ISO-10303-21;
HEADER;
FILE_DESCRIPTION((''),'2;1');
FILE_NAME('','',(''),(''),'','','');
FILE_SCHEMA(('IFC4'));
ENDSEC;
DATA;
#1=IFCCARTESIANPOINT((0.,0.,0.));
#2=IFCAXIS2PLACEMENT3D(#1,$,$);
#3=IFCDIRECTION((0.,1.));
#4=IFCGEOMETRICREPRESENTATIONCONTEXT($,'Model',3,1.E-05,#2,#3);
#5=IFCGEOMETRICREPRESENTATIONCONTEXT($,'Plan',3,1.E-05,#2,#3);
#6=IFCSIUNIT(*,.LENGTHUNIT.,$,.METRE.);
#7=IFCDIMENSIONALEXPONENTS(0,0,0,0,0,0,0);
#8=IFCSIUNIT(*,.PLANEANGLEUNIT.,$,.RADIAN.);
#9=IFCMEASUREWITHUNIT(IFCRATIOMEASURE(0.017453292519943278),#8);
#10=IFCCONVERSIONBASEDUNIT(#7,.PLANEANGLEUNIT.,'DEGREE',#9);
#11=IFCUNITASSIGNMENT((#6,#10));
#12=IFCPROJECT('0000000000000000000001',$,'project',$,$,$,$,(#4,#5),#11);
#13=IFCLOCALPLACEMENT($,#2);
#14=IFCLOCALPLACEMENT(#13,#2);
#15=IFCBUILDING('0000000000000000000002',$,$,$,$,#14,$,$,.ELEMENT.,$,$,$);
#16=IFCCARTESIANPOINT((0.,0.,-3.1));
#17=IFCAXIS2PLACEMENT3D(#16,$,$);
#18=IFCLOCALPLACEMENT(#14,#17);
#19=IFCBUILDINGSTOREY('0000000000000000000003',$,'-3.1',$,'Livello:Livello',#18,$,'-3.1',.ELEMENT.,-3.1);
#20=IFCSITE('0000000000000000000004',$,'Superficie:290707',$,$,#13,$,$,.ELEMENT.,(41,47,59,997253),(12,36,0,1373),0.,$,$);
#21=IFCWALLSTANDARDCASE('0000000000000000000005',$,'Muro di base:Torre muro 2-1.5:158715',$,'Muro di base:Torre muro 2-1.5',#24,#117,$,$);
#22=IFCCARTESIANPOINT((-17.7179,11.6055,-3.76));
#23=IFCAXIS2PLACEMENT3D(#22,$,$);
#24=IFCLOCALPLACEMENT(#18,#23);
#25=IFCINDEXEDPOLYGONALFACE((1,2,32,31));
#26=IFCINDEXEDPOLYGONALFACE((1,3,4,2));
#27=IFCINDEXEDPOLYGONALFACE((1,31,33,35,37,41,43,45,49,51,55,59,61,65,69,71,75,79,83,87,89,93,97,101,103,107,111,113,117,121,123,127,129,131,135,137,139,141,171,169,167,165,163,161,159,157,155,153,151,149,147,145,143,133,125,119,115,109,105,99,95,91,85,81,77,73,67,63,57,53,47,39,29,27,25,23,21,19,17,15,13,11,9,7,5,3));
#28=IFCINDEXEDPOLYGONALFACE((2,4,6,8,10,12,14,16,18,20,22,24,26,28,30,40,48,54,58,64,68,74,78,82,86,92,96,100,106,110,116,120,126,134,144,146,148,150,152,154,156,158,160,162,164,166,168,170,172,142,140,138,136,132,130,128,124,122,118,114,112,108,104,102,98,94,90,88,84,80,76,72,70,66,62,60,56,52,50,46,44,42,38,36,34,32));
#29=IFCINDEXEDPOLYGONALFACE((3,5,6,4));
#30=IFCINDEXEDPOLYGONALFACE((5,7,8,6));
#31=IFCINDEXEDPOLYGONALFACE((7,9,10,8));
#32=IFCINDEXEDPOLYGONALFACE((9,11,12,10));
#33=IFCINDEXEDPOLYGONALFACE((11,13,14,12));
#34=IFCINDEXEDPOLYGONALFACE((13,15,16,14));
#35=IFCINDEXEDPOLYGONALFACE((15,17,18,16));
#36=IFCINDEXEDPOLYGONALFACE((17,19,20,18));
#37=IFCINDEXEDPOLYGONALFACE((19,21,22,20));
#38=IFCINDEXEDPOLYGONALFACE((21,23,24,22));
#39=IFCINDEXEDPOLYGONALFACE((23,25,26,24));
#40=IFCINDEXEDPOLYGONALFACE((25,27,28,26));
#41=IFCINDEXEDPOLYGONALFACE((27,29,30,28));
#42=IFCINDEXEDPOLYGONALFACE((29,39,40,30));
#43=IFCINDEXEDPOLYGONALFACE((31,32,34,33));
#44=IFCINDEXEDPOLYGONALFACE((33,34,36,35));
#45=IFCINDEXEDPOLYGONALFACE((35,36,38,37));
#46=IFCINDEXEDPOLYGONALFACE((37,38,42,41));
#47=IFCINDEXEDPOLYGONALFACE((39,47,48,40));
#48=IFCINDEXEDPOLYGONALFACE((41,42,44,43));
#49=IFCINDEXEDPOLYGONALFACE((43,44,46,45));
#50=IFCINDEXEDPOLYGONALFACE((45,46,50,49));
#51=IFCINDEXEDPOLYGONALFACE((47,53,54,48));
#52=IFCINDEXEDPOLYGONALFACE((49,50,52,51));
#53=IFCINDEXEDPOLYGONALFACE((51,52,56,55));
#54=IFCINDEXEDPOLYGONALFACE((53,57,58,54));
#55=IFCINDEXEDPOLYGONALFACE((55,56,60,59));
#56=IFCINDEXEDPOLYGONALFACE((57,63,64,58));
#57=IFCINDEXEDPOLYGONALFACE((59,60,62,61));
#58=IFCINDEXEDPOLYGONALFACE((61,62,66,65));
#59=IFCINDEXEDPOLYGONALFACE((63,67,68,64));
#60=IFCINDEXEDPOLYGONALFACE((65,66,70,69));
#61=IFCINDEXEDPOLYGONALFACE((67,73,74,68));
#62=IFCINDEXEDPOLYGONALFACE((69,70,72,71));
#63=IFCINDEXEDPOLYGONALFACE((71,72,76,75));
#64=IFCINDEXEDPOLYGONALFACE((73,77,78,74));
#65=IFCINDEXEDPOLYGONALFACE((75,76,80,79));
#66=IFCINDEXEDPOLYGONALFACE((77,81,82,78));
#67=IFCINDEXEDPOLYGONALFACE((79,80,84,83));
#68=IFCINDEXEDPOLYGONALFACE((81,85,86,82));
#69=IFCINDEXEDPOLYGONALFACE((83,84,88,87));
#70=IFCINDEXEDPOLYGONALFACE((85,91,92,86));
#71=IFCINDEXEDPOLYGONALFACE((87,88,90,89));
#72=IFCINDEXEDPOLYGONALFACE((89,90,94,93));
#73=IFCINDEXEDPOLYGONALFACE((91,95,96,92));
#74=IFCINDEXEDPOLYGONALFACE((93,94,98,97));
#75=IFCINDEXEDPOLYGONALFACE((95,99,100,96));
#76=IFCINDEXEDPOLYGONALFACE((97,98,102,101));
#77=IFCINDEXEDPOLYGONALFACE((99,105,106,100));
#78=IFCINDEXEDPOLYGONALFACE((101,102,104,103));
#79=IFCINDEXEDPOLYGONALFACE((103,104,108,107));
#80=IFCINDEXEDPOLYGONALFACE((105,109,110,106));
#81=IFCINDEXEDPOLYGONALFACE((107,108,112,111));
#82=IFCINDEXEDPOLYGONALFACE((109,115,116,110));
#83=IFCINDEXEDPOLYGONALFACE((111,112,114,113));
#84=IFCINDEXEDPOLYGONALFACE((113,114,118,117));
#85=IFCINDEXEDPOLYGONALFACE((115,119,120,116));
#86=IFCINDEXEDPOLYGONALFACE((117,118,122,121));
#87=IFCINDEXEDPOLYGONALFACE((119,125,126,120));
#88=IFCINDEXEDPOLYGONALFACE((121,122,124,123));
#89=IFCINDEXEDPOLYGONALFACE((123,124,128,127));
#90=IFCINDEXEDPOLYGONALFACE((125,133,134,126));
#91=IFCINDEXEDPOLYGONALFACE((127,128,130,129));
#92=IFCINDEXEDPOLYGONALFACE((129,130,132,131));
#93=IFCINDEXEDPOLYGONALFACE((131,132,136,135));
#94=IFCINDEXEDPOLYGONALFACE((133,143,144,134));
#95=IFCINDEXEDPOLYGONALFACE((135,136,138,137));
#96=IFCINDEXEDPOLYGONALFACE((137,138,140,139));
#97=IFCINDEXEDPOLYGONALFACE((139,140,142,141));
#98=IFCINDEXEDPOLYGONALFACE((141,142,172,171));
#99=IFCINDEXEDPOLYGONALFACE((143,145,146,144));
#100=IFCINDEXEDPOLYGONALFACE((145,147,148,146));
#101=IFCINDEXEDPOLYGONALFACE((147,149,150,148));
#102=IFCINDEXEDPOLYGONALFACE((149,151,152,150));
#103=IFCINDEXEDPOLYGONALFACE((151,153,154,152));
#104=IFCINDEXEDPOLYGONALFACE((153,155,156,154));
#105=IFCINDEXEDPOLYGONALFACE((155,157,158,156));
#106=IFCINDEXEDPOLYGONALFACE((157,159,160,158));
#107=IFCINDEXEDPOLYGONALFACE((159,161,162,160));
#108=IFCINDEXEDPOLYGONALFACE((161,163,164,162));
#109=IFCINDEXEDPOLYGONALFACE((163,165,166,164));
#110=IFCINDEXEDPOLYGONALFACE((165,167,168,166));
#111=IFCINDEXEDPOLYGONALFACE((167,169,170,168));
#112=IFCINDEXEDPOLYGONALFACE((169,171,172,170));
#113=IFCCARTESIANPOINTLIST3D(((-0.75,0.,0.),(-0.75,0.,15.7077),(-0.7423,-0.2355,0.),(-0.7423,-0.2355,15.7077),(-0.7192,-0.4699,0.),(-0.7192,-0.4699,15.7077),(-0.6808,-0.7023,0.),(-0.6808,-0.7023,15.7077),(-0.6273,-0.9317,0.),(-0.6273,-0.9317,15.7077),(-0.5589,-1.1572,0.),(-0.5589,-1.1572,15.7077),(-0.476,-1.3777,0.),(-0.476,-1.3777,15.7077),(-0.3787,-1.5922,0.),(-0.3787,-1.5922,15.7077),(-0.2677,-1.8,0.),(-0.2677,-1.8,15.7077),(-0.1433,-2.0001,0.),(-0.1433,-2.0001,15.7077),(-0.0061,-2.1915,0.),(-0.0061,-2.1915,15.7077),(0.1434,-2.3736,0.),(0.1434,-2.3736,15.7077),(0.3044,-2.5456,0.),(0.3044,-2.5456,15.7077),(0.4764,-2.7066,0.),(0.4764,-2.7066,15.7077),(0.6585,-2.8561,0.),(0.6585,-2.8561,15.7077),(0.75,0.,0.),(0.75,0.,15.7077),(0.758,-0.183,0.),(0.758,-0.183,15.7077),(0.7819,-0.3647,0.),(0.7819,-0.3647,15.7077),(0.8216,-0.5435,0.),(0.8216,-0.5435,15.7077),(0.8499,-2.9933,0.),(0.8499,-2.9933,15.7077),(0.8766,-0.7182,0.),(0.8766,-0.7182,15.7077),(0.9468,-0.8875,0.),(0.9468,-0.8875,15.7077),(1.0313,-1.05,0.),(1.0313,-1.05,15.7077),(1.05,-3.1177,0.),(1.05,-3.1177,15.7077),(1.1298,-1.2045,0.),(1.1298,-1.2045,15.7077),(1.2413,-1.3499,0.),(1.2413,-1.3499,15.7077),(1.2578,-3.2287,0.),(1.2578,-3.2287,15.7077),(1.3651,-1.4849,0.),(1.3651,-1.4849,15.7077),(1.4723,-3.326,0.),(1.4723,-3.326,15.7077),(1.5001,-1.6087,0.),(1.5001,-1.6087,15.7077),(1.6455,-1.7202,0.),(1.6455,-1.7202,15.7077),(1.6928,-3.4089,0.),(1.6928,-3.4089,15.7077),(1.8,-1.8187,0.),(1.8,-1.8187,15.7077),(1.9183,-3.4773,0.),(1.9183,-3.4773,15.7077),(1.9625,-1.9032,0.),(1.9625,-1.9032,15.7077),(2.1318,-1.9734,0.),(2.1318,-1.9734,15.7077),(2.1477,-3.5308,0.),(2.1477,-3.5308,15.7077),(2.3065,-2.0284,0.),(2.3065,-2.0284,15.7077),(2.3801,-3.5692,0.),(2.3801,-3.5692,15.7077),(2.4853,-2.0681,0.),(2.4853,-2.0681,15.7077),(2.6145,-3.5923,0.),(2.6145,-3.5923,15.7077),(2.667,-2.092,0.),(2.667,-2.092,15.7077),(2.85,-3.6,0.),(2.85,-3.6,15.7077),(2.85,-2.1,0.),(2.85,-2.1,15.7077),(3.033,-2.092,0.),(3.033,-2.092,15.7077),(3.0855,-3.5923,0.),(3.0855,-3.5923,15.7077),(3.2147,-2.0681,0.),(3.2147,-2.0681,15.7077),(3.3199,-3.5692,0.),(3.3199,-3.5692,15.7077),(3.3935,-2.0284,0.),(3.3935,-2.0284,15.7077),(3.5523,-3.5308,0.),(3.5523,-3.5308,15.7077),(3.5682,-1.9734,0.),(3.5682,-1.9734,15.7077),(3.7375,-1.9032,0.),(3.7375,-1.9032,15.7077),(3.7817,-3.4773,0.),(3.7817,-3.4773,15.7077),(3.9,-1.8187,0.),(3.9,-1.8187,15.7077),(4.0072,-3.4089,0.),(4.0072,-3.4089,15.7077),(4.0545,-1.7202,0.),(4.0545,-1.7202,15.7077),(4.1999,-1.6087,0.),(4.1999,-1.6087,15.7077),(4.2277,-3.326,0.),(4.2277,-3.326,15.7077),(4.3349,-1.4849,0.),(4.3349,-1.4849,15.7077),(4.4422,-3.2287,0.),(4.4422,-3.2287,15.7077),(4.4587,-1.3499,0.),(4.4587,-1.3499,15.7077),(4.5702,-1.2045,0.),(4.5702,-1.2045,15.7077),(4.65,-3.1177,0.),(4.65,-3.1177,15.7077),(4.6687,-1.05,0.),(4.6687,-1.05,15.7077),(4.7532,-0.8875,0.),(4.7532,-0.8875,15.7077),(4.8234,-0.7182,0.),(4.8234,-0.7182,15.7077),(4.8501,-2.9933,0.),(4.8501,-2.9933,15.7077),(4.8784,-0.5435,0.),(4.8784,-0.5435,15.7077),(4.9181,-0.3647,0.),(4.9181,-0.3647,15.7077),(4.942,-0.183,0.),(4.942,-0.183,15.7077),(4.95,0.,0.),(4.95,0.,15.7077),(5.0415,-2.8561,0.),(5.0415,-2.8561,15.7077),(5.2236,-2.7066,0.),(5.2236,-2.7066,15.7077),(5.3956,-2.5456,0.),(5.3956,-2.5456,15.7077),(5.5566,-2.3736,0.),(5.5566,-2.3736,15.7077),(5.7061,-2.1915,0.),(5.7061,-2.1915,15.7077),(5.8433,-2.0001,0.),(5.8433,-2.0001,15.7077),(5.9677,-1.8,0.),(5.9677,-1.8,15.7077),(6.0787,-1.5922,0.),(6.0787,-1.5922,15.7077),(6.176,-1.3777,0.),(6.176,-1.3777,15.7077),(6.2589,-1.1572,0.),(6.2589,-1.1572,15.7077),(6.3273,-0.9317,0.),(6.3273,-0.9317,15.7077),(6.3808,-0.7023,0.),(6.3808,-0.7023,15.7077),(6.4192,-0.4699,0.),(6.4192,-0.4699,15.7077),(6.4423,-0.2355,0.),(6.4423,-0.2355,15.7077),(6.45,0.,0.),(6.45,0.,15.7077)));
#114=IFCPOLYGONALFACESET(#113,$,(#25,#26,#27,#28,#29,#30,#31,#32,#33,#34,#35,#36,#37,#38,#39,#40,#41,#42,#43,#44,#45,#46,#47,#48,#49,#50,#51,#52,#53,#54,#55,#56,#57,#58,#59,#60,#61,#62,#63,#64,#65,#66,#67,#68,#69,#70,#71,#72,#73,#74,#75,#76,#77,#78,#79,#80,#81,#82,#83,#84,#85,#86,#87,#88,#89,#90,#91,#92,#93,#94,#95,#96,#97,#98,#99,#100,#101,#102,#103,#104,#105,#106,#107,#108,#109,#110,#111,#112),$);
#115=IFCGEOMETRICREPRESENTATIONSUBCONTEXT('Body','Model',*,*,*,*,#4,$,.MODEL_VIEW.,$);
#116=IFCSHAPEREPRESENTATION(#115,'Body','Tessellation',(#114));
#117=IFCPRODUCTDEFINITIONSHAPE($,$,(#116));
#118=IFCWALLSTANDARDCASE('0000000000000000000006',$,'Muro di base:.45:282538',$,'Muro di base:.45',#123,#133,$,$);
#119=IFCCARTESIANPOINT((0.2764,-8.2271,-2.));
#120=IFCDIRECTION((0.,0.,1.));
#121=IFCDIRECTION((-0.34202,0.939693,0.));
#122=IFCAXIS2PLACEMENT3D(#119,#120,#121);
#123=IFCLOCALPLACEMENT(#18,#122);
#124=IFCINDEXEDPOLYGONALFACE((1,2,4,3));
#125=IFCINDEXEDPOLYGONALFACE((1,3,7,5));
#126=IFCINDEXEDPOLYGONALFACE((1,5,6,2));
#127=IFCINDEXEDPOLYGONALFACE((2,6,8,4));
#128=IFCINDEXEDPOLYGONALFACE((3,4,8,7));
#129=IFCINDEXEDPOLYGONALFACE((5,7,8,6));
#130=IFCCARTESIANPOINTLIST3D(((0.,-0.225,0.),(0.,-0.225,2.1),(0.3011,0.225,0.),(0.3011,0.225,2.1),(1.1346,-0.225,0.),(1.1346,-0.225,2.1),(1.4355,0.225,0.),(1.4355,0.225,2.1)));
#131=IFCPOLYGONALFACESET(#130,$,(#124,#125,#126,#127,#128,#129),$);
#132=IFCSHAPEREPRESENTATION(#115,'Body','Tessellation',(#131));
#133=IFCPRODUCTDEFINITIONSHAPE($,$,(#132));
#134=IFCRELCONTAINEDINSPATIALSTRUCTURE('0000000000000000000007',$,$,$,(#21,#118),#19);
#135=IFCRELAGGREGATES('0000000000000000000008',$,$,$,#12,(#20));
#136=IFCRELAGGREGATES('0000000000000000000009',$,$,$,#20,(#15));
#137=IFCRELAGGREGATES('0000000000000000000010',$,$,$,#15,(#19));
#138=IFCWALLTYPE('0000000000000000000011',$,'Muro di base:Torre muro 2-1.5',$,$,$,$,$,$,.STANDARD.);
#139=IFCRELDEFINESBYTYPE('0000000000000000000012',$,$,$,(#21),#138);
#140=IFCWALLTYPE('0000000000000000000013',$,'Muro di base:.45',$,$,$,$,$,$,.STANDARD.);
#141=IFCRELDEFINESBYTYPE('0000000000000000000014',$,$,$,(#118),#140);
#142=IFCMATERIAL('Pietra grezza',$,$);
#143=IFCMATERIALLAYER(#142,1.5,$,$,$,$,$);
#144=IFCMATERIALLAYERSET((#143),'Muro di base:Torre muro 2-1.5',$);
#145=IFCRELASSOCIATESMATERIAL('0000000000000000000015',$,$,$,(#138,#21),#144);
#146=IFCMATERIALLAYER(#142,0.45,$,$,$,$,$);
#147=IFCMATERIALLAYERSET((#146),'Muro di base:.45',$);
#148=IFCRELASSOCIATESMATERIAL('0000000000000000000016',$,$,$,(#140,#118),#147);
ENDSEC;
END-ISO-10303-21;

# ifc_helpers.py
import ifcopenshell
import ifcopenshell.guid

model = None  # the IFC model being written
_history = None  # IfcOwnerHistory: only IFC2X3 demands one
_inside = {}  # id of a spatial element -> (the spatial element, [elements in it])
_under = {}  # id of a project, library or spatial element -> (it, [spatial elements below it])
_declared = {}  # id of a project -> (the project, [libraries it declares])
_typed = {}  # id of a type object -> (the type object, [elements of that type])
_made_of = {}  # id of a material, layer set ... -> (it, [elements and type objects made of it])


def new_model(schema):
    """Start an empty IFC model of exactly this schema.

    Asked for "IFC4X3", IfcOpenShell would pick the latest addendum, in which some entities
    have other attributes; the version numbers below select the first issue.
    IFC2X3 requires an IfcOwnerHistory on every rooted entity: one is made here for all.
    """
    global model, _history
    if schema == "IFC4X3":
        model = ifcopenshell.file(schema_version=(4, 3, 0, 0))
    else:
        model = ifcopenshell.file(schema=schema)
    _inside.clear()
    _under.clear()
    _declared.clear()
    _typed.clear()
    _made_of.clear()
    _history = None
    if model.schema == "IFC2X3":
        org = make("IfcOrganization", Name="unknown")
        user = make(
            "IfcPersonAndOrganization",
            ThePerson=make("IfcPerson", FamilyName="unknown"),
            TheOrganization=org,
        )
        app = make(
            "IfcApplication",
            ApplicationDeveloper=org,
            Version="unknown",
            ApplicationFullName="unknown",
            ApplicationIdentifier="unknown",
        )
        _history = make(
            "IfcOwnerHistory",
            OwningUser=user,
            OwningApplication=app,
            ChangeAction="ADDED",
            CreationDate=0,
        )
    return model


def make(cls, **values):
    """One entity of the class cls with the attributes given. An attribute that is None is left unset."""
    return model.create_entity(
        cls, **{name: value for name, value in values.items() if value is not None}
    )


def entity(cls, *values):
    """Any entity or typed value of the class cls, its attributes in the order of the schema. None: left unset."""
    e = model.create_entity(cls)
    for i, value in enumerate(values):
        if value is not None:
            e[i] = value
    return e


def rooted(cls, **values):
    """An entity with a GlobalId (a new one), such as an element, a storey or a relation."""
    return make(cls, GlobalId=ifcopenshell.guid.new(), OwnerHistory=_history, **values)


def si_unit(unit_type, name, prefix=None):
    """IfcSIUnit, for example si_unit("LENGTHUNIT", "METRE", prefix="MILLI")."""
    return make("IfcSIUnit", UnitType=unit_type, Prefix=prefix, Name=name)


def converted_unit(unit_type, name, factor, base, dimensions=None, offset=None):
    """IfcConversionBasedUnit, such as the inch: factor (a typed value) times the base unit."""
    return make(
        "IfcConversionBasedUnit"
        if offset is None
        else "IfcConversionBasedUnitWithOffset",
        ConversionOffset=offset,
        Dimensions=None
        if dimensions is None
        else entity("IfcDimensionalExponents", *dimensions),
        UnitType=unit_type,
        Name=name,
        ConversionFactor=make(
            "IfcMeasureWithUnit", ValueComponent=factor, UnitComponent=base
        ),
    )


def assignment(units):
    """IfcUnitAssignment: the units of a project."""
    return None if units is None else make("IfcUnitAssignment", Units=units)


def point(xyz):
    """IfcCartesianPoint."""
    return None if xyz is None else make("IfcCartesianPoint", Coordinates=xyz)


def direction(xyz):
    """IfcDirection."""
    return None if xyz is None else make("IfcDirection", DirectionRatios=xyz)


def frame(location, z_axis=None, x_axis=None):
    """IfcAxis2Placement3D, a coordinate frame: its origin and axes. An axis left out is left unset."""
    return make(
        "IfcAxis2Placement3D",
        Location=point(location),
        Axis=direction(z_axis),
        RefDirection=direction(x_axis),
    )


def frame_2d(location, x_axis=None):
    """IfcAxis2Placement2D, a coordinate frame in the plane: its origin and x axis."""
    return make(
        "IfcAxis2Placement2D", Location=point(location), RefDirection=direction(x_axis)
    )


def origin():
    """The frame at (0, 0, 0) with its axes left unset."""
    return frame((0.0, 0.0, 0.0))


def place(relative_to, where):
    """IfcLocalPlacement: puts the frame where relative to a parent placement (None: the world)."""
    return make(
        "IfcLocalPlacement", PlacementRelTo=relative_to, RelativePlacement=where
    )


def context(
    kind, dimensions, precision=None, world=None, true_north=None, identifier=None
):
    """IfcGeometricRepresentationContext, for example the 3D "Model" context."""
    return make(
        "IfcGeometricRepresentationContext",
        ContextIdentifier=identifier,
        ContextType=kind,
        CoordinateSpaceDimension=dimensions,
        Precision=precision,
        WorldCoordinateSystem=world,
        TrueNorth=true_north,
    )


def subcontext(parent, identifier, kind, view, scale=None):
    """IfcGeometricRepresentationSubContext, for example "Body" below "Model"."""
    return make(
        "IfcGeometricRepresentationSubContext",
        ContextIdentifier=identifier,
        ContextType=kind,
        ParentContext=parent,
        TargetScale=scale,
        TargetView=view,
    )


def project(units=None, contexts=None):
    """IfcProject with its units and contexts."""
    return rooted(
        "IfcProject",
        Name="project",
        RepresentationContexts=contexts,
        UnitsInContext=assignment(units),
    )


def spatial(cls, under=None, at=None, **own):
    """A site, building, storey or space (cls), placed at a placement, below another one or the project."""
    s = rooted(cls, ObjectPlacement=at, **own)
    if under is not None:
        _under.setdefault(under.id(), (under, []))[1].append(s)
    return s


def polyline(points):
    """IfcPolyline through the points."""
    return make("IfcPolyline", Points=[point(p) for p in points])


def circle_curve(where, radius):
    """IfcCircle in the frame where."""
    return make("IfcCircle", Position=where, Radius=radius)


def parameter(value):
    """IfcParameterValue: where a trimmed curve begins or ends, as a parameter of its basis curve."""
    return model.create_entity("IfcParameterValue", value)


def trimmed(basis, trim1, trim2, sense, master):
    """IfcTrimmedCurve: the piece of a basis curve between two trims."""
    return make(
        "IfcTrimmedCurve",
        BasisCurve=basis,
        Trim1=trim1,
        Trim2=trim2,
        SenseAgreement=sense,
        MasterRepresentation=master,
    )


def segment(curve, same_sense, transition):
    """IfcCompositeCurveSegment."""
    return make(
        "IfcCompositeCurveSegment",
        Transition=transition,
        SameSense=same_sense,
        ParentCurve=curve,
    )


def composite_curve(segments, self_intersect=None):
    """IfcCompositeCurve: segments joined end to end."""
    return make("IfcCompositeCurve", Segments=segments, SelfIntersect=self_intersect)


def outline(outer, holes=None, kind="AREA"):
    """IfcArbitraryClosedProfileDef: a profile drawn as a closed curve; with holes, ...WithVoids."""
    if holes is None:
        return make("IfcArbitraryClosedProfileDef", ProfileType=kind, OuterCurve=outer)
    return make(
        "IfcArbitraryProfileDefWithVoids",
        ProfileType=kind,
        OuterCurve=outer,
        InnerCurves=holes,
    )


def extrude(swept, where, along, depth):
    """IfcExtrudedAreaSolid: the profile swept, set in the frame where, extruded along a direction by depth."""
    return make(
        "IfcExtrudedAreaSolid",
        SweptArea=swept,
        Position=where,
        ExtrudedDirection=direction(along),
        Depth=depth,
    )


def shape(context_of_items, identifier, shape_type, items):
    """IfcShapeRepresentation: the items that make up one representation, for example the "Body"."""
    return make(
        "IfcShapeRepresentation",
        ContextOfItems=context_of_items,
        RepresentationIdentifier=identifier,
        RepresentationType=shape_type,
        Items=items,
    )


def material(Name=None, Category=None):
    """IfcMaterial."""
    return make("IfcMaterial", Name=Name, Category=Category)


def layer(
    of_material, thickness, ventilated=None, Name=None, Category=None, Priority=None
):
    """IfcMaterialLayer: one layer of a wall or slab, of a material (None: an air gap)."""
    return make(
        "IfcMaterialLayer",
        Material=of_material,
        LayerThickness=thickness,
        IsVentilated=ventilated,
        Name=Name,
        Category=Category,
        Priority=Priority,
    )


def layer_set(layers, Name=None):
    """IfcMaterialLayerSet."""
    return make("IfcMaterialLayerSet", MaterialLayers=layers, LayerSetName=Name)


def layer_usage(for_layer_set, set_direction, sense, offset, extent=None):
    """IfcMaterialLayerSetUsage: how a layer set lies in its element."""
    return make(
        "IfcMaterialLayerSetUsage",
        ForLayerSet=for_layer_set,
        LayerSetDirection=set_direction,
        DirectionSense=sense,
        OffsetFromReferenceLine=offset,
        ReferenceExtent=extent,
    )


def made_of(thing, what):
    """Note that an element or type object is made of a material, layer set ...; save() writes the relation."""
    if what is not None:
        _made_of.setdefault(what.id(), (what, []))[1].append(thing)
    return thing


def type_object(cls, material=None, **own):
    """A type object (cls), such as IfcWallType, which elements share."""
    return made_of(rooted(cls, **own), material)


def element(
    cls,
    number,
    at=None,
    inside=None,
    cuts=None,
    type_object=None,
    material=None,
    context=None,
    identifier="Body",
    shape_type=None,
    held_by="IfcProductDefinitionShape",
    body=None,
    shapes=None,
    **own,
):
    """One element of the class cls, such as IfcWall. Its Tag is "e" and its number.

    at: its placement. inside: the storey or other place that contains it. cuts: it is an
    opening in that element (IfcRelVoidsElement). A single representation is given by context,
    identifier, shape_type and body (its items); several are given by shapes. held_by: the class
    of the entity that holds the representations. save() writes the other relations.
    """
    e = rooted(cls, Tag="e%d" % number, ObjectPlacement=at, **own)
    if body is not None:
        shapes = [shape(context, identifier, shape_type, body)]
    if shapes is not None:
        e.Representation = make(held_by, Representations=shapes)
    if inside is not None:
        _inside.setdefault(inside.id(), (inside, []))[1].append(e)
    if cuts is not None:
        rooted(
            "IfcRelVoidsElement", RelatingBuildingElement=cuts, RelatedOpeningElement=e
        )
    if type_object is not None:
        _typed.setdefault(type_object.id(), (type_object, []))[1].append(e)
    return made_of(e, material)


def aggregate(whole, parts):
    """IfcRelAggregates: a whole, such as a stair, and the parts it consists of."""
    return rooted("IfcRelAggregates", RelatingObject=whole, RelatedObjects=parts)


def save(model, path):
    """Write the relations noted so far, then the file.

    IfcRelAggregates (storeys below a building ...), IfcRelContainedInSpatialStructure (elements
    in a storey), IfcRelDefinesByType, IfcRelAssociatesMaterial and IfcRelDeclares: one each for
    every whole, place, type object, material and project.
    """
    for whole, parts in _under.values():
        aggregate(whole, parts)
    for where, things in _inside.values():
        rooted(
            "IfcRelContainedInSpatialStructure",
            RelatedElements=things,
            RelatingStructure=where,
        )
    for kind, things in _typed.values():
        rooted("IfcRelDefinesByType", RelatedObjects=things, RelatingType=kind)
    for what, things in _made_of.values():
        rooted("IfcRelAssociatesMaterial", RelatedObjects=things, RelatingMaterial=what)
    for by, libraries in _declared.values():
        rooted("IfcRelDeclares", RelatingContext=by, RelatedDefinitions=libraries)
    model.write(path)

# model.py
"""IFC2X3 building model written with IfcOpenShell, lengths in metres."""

from ifc_helpers import new_model, entity, si_unit, converted_unit, direction, frame, frame_2d, origin, place, context, subcontext, project, spatial, polyline, circle_curve, parameter, trimmed, segment, composite_curve, outline, extrude, material, layer, layer_set, layer_usage, type_object, element, save


model = new_model("IFC2X3")

# Units and contexts
model_context = context("Model", 3, precision=1e-05, world=origin(), true_north=direction((0.0, 1.0)))
plan_context = context("Plan", 3, precision=1e-05, world=origin(), true_north=direction((0.0, 1.0)))
body_context = subcontext(model_context, "Body", "Model", "MODEL_VIEW")
ifc_project = project(units=[si_unit("LENGTHUNIT", "METRE"), converted_unit("PLANEANGLEUNIT", "DEGREE", entity("IfcRatioMeasure", 0.017453292519943278), si_unit("PLANEANGLEUNIT", "RADIAN"), dimensions=[0, 0, 0, 0, 0, 0, 0])], contexts=[model_context, plan_context])

# Site, building, storey
site_placement = place(None, origin())
site = spatial("IfcSite", under=ifc_project, at=site_placement, Name="Superficie:290707", CompositionType="ELEMENT", RefLatitude=(41, 47, 59, 997253), RefLongitude=(12, 36, 0, 1373), RefElevation=0.0)
building_placement = place(site_placement, origin())
building = spatial("IfcBuilding", under=site, at=building_placement, CompositionType="ELEMENT")
storey_placement = place(building_placement, frame((0.0, 0.0, -3.1)))
storey = spatial("IfcBuildingStorey", under=building, at=storey_placement, Name="-3.1", ObjectType="Livello:Livello", LongName="-3.1", CompositionType="ELEMENT", Elevation=-3.1)

# Walls
ifc_material_1 = material(Name="Pietra grezza")
ifc_layer_1 = layer(ifc_material_1, 1.5)
ifc_layer_set_1 = layer_set([ifc_layer_1], Name="Muro di base:Torre muro 2-1.5")
ifc_layer_usage_1 = layer_usage(ifc_layer_set_1, "AXIS2", "NEGATIVE", 0.75)
wall_type_1 = type_object("IfcWallType", Name="Muro di base:Torre muro 2-1.5", PredefinedType="STANDARD", material=ifc_layer_set_1)
wall_1_placement = place(storey_placement, frame((-17.7179, 11.6055, -3.76)))
element("IfcWallStandardCase", 1, at=wall_1_placement, inside=storey, type_object=wall_type_1, material=ifc_layer_usage_1, Name="Muro di base:Torre muro 2-1.5:158715", ObjectType="Muro di base:Torre muro 2-1.5", context=body_context, shape_type="SweptSolid", body=[
    extrude(outline(composite_curve([segment(trimmed(circle_curve(frame_2d((2.85, 0.0), x_axis=(1.0, 0.0)), 2.1), [parameter(180.0)], [parameter(0.0)], True, "PARAMETER"), False, "CONTINUOUS"), segment(polyline([(0.75, 0.0), (-0.75, 0.0)]), True, "CONTINUOUS"), segment(trimmed(circle_curve(frame_2d((2.85, 0.0), x_axis=(1.0, 0.0)), 3.6), [parameter(180.0)], [parameter(0.0)], True, "PARAMETER"), True, "CONTINUOUS"), segment(polyline([(6.45, 0.0), (4.95, 0.0)]), True, "CONTINUOUS")], self_intersect=False)), origin(), (0.0, 0.0, 1.0), 15.7077),
])
ifc_layer_2 = layer(ifc_material_1, 0.45)
ifc_layer_set_2 = layer_set([ifc_layer_2], Name="Muro di base:.45")
ifc_layer_usage_2 = layer_usage(ifc_layer_set_2, "AXIS2", "NEGATIVE", 0.225)
wall_type_2 = type_object("IfcWallType", Name="Muro di base:.45", PredefinedType="STANDARD", material=ifc_layer_set_2)
wall_2_placement = place(storey_placement, frame((0.2764, -8.2271, -2.0), z_axis=(0.0, 0.0, 1.0), x_axis=(-0.34202, 0.939693, 0.0)))
element("IfcWallStandardCase", 2, at=wall_2_placement, inside=storey, type_object=wall_type_2, material=ifc_layer_usage_2, Name="Muro di base:.45:282538", ObjectType="Muro di base:.45", context=body_context, shape_type="SweptSolid", body=[
    extrude(outline(polyline([(0.0446, -0.4716), (0.5859, -0.4716), (-0.0445, 0.4715), (-0.586, 0.4717), (0.0446, -0.4716)])), frame((0.7178, 0.0, 0.0), z_axis=(0.0, 0.0, 1.0), x_axis=(0.555801, 0.831316, 0.0)), (0.0, 0.0, 1.0), 2.1),
])

save(model, "model.ifc")
